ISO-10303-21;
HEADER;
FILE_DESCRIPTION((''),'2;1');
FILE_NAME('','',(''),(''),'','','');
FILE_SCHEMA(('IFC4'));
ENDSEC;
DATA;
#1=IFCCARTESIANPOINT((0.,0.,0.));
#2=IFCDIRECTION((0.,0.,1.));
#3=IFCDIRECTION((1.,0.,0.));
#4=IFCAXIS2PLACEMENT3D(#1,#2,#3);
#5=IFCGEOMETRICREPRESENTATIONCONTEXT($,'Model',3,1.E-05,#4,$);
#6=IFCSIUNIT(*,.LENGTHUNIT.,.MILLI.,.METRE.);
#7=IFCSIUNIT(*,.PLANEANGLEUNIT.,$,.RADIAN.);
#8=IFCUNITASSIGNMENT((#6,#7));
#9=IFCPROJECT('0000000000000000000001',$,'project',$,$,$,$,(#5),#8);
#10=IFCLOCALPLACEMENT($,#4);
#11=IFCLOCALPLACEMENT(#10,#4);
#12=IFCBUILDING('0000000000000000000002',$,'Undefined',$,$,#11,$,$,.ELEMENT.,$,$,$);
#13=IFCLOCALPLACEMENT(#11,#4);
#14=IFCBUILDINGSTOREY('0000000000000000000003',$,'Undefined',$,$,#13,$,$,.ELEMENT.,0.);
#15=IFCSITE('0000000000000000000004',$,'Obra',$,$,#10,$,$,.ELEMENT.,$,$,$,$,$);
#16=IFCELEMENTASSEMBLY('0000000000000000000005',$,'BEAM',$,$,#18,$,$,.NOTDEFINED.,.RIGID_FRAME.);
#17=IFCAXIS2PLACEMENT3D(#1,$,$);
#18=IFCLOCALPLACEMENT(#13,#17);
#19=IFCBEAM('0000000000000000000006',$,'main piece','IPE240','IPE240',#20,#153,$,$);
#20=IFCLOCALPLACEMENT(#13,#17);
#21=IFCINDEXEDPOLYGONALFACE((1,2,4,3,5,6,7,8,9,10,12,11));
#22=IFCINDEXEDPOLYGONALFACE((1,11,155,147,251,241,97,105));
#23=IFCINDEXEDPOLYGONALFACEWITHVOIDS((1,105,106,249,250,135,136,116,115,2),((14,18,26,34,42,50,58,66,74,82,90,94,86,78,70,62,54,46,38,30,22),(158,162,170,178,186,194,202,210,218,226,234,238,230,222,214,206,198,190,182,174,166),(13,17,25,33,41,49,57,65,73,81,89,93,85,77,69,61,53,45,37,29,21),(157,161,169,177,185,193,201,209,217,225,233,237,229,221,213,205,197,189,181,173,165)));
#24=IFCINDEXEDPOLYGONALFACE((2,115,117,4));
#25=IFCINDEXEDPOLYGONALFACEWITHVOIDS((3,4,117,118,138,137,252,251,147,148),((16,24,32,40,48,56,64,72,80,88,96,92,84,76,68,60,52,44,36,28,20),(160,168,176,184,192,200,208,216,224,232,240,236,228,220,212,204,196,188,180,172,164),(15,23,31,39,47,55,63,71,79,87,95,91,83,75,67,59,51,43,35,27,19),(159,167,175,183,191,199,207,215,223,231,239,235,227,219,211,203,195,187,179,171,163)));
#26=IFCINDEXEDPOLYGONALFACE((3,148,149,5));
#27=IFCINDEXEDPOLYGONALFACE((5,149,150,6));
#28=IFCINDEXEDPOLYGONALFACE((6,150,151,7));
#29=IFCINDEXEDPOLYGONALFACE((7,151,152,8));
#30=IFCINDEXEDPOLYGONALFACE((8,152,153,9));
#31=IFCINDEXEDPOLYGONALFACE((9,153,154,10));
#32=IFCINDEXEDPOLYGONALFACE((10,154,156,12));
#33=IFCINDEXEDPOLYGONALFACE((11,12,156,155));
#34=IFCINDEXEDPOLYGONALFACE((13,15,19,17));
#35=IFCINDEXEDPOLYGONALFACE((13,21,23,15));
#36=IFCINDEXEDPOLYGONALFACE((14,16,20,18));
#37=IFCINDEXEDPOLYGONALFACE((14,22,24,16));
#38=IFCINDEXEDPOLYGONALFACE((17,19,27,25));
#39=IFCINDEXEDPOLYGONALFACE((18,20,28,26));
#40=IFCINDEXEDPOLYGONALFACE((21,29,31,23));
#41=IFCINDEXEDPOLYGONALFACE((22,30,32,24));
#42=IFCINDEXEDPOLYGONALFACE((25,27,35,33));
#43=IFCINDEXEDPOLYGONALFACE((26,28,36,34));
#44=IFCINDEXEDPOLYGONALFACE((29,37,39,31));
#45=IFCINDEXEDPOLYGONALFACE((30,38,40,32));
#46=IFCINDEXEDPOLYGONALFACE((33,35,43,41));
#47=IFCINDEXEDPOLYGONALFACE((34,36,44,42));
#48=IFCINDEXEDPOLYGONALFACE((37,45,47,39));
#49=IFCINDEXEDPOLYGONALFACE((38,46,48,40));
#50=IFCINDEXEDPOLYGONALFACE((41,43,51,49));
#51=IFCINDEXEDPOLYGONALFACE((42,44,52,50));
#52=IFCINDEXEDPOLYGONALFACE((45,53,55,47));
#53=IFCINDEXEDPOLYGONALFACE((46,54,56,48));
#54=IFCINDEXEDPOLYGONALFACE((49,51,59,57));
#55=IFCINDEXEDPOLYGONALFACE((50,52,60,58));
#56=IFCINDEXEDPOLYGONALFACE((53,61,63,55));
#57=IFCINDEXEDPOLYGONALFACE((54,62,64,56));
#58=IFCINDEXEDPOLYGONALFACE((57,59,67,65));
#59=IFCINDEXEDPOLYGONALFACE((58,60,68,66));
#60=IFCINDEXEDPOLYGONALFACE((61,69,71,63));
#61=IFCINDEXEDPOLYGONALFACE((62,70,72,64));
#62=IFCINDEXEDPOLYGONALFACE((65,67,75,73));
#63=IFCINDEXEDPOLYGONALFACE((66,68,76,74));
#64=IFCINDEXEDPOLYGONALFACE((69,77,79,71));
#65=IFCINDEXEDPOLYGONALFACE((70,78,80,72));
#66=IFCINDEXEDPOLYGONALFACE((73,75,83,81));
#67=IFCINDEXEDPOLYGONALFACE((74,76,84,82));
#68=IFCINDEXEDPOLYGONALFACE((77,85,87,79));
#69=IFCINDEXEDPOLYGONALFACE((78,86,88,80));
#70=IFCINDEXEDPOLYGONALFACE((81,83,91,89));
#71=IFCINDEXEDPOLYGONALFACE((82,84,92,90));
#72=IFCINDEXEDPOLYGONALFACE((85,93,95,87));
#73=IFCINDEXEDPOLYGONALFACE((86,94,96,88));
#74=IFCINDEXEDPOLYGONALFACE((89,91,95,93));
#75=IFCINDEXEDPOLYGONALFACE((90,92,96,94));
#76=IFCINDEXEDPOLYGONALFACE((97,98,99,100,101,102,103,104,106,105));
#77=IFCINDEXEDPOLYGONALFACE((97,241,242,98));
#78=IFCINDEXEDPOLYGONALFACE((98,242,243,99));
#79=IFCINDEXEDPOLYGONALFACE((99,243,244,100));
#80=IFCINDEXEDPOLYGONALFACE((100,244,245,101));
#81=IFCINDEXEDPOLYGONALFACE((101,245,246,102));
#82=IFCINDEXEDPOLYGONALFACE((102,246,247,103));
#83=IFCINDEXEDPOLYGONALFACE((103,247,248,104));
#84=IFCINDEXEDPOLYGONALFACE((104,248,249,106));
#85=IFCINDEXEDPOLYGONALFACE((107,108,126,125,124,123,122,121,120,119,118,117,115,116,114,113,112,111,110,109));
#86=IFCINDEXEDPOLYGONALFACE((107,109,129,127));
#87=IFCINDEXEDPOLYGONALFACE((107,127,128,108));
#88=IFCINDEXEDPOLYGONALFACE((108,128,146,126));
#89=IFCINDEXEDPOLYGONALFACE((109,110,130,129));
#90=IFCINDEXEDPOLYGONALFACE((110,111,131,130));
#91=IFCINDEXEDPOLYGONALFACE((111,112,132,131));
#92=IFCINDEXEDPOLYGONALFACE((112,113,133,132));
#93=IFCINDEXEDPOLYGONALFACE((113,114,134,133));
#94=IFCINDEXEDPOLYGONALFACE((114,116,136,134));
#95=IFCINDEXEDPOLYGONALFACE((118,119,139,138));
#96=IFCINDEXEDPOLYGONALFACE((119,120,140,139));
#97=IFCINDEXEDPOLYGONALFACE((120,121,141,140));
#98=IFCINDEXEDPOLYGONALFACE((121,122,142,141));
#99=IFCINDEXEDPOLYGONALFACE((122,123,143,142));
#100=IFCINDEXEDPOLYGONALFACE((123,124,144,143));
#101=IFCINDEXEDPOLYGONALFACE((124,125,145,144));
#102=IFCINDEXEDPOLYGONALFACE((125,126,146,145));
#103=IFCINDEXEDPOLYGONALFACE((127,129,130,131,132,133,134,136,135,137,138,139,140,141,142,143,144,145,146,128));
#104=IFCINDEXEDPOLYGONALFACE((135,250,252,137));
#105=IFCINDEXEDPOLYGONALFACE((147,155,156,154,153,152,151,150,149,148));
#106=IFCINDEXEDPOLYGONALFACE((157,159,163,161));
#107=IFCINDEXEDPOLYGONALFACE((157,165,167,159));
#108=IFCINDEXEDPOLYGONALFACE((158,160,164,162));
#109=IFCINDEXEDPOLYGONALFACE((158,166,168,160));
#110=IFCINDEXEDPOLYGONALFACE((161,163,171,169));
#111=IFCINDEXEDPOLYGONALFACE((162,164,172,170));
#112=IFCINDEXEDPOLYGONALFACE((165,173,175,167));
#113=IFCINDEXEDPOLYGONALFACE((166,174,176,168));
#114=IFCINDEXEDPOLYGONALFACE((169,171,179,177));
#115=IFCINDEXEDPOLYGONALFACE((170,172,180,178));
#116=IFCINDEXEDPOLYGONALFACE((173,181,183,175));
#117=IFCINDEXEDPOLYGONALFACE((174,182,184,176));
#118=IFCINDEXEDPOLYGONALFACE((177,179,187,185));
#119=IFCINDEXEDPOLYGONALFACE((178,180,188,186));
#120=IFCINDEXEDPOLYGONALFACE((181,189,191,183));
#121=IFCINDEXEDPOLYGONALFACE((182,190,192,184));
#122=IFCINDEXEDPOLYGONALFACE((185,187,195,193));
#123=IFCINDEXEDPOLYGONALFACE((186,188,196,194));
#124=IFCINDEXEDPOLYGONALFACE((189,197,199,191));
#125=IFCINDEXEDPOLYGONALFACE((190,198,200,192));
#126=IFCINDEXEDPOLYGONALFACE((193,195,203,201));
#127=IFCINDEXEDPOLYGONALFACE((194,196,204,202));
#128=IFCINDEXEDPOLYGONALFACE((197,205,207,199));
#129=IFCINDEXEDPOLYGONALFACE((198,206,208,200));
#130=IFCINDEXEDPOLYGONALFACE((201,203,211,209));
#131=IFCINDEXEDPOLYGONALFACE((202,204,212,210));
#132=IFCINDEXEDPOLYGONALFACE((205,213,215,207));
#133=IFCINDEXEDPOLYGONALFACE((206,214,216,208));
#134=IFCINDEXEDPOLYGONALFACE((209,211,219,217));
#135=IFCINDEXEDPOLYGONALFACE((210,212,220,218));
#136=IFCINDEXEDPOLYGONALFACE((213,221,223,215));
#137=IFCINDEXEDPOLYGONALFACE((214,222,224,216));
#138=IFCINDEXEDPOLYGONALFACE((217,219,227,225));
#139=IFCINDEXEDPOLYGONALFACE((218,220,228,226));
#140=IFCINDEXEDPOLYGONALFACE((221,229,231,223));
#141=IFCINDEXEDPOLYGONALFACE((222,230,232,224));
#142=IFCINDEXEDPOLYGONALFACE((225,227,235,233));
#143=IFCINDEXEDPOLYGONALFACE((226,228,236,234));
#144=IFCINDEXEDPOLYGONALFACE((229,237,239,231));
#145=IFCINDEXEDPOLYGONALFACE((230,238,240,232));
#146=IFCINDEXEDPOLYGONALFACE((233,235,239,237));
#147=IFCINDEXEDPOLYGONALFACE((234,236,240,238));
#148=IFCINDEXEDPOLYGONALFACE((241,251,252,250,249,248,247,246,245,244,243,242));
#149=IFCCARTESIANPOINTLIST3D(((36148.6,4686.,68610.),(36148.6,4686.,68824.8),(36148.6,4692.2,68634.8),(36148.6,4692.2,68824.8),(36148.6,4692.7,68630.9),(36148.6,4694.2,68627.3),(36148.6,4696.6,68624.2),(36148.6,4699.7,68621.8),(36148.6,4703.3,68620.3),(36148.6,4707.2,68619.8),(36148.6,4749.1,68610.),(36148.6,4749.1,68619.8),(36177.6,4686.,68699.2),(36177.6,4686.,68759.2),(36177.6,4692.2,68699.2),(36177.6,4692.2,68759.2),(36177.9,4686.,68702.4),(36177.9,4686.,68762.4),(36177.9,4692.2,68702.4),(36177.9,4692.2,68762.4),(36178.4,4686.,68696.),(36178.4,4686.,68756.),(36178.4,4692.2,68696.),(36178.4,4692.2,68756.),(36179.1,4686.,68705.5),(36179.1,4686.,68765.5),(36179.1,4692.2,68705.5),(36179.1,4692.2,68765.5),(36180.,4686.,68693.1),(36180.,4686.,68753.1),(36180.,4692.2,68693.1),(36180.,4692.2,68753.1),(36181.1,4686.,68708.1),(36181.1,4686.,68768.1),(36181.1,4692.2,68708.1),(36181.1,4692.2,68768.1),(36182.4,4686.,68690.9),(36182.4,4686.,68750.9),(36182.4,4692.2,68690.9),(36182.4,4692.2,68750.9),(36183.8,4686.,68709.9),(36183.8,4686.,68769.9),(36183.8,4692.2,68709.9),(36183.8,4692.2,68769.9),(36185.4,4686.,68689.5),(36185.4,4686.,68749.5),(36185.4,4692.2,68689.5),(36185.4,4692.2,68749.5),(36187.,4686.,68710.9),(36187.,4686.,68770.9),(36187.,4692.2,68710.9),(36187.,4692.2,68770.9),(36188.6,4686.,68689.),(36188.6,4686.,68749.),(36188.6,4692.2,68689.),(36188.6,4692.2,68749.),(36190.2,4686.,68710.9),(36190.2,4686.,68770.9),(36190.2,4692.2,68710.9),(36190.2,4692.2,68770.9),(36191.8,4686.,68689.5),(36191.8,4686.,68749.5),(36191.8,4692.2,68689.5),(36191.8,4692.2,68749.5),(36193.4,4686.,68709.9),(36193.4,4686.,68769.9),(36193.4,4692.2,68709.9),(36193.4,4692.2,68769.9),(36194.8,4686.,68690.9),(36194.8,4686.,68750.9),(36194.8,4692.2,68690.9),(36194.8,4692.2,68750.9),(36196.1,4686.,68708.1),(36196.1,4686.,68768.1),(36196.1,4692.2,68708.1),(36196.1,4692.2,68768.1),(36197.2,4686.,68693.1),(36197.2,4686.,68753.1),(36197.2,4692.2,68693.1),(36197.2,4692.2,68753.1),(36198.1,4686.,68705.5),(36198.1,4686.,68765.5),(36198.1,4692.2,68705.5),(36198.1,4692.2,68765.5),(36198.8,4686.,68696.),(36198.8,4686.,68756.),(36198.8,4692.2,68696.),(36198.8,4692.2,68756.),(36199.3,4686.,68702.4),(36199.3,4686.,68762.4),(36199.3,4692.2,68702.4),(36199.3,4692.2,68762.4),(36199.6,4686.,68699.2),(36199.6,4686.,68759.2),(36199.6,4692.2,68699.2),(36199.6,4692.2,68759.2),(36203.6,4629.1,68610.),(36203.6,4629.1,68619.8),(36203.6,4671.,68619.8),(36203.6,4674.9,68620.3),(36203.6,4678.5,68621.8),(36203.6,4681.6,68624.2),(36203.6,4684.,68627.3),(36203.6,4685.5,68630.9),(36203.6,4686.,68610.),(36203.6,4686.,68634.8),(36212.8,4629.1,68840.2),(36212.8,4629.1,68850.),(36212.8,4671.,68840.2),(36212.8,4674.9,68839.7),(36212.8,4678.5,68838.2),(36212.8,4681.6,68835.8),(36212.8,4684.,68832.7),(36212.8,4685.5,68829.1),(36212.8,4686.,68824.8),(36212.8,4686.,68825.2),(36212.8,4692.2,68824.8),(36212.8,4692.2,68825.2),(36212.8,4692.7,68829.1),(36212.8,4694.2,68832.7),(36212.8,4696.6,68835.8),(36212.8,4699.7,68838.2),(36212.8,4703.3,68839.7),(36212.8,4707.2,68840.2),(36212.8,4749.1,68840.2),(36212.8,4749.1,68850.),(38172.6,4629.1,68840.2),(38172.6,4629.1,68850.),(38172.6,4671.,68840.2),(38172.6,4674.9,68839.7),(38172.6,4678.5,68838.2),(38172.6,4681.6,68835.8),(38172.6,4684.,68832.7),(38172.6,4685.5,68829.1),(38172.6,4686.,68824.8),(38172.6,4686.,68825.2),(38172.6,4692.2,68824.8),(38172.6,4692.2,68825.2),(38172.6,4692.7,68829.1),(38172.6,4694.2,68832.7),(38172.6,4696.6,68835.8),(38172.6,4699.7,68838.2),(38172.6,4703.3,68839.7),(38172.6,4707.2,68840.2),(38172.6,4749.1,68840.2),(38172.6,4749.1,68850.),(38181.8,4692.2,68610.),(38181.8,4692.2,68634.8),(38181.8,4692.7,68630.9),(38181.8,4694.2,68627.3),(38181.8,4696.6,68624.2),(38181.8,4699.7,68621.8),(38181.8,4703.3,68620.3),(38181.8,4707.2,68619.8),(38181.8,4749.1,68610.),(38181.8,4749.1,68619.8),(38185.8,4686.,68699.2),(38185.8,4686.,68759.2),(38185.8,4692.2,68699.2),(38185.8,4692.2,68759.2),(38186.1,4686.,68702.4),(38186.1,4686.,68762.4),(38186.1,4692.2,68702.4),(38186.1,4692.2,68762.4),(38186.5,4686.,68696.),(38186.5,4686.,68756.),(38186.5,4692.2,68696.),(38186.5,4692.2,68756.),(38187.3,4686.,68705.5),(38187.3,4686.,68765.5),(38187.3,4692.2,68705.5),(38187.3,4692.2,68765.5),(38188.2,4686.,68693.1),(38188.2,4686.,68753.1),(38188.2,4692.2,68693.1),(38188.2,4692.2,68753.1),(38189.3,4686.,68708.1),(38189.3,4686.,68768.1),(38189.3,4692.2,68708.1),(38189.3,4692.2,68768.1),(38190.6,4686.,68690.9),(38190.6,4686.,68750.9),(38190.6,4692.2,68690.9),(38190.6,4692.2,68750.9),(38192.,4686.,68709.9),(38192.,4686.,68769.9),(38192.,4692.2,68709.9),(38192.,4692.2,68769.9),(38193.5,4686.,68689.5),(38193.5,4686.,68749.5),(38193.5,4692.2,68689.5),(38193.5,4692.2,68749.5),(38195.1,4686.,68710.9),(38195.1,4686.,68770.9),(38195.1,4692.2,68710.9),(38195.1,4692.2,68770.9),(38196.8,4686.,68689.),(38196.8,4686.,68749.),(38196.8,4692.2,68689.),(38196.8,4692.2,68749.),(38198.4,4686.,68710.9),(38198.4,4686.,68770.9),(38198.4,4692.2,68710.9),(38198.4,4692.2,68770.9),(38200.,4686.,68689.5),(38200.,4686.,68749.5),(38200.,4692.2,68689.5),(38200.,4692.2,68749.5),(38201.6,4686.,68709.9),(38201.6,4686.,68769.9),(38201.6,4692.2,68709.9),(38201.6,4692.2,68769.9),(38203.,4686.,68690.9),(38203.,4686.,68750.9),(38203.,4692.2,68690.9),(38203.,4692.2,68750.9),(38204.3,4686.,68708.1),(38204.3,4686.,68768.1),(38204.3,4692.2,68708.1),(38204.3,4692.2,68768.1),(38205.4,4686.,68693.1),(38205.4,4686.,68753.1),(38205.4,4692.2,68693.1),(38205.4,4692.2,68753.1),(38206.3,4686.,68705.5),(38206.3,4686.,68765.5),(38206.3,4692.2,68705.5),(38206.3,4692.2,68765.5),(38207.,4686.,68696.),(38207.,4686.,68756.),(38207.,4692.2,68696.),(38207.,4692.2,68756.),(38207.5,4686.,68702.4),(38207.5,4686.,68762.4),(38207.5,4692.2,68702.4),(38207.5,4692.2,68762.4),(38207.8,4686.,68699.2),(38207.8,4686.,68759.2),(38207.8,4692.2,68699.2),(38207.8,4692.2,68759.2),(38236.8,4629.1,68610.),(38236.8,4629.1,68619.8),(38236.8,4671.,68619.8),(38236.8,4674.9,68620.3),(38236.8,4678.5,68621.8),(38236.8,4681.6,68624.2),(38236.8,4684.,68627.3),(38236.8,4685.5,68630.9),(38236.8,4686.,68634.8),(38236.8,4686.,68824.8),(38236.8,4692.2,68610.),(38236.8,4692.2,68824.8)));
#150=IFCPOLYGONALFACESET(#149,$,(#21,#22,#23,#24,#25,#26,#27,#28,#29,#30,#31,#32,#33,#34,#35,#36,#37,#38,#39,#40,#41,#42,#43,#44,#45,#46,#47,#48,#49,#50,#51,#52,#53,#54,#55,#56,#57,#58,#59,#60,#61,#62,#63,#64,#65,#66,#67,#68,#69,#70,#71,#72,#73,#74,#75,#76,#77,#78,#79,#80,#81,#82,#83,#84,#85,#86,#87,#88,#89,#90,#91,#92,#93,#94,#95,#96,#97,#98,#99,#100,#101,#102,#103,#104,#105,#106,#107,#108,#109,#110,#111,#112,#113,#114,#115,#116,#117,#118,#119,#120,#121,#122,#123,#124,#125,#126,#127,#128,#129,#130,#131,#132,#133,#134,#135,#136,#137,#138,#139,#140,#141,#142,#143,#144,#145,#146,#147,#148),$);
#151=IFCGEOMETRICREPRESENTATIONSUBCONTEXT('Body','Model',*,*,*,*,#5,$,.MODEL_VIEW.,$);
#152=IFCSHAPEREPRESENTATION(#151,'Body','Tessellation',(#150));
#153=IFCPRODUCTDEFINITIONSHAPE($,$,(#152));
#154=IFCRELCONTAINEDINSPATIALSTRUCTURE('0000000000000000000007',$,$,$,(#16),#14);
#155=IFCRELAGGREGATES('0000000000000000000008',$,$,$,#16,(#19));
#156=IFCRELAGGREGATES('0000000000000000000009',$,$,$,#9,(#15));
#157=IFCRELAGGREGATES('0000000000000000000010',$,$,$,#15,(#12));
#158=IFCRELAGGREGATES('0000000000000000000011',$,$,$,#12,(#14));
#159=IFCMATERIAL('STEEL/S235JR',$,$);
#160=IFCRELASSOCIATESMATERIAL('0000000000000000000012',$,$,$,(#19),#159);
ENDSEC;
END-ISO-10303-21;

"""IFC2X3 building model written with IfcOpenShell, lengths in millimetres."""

from ifc_helpers import new_model, si_unit, frame, origin_with_axes, origin_2d_with_axis, place, context, subcontext, project, spatial, rectangle, circle, i_section, extrude, clip, halfspace, source, transform, mapped, material, element, aggregate, save


model = new_model("IFC2X3")

# Units and contexts
model_context = context("Model", 3, precision=1e-05, world=origin_with_axes())
body_context = subcontext(model_context, "Body", "Model", "MODEL_VIEW")
ifc_project = project(units=[si_unit("LENGTHUNIT", "METRE", prefix="MILLI"), si_unit("PLANEANGLEUNIT", "RADIAN")], contexts=[model_context])

# Site, building, storey
site_placement = place(None, origin_with_axes())
site = spatial("IfcSite", under=ifc_project, at=site_placement, Name="Obra", CompositionType="ELEMENT")
building_placement = place(site_placement, origin_with_axes())
building = spatial("IfcBuilding", under=site, at=building_placement, Name="Undefined", CompositionType="ELEMENT")
storey_placement = place(building_placement, origin_with_axes())
storey = spatial("IfcBuildingStorey", under=building, at=storey_placement, Name="Undefined", CompositionType="ELEMENT", Elevation=0.0)

# Element assembly, beam, openings
ifc_material_1 = material(Name="STEEL/S235JR")
shared_shape_1 = source(origin_with_axes(), body_context, "Body", "SweptSolid", [
    extrude(circle(Radius=11.0, at=origin_2d_with_axis()), frame((0.0, -3.2, 0.0), z_axis=(0.0, 1.0, 0.0), x_axis=(1.0, 0.0, 0.0)), (0.0, 0.0, 1.0), 6.4),
])
assembly_1_placement = place(storey_placement, origin_with_axes())
assembly_1 = element("IfcElementAssembly", 1, at=assembly_1_placement, inside=storey, Name="BEAM", AssemblyPlace="NOTDEFINED", PredefinedType="RIGID_FRAME")
beam_1_placement = place(assembly_1_placement, frame((38169.8, 4689.1, 68730.0), z_axis=(0.0, 0.0, 1.0), x_axis=(-1.0, 0.0, 0.0)))
beam_1 = element("IfcBeam", 2, at=beam_1_placement, material=ifc_material_1, Name="main piece", Description="IPE240", ObjectType="IPE240", context=body_context, shape_type="Clipping", body=[
    clip(clip(extrude(i_section(OverallWidth=120.0, OverallDepth=240.0, WebThickness=6.2, FlangeThickness=9.8, FilletRadius=15.0, at=origin_2d_with_axis()), frame((2021.2, 0.0, 0.0), z_axis=(-1.0, 0.0, 0.0), x_axis=(0.0, -1.0, 0.0)), (0.0, 0.0, 1.0), 2088.2), halfspace(frame((2021.2, 0.0, -220.0), z_axis=(-1.0, 0.0, 0.0), x_axis=(0.0, 1.0, 0.0)), True)), halfspace(frame((-66.9, 0.0, -220.0), z_axis=(1.0, 0.0, 0.0), x_axis=(0.0, -1.0, 0.0)), True)),
])
opening_1_placement = place(assembly_1_placement, frame((38169.8, 4689.1, 68730.0), z_axis=(0.0, 0.0, 1.0), x_axis=(-1.0, 0.0, 0.0)))
element("IfcOpeningElement", 3, at=opening_1_placement, cuts=beam_1, ObjectType="Recess", context=body_context, shape_type="SweptSolid", body=[
    extrude(rectangle(XDim=65.0, YDim=300.0, at=origin_2d_with_axis()), frame((-44.4, -153.1, 109.8), z_axis=(0.0, 0.0, -1.0), x_axis=(1.0, 0.0, 0.0)), (0.0, 0.0, 1.0), 249.6),
])
opening_2_placement = place(assembly_1_placement, frame((38169.8, 4689.1, 68730.0), z_axis=(0.0, 0.0, 1.0), x_axis=(-1.0, 0.0, 0.0)))
element("IfcOpeningElement", 4, at=opening_2_placement, cuts=beam_1, ObjectType="Recess", context=body_context, shape_type="SweptSolid", body=[
    extrude(rectangle(XDim=26.2, YDim=76.2, at=origin_2d_with_axis()), frame((-40.8, -61.0, 107.9), z_axis=(0.0, 1.0, 0.0), x_axis=(0.0, 0.0, -1.0)), (0.0, 0.0, 1.0), 122.0),
])
opening_3_placement = place(assembly_1_placement, frame((38169.8, 4689.1, 68730.0), z_axis=(0.0, 0.0, 1.0), x_axis=(-1.0, 0.0, 0.0)))
element("IfcOpeningElement", 5, at=opening_3_placement, cuts=beam_1, ObjectType="Recess", context=body_context, shape_type="SweptSolid", body=[
    extrude(rectangle(XDim=65.0, YDim=300.0, at=origin_2d_with_axis()), frame((1998.7, 153.1, 109.8), z_axis=(0.0, 0.0, -1.0), x_axis=(-1.0, 0.0, 0.0)), (0.0, 0.0, 1.0), 249.6),
])
opening_4_placement = place(assembly_1_placement, frame((38169.8, 4689.1, 68730.0), z_axis=(0.0, 0.0, 1.0), x_axis=(-1.0, 0.0, 0.0)))
element("IfcOpeningElement", 6, at=opening_4_placement, cuts=beam_1, ObjectType="Recess", context=body_context, shape_type="SweptSolid", body=[
    extrude(rectangle(XDim=26.2, YDim=76.2, at=origin_2d_with_axis()), frame((1995.1, 61.0, 107.9), z_axis=(0.0, -1.0, 0.0), x_axis=(0.0, 0.0, -1.0)), (0.0, 0.0, 1.0), 122.0),
])
opening_5_placement = place(assembly_1_placement, frame((38236.8, 4689.1, 68850.0), z_axis=(-1.0, 0.0, 0.0), x_axis=(0.0, 0.0, -1.0)))
element("IfcOpeningElement", 7, at=opening_5_placement, cuts=beam_1, ObjectType="Opening", context=body_context, shape_type="MappedRepresentation", body=[
    mapped(shared_shape_1, transform((90.0, 0.0, 40.0))),
    mapped(shared_shape_1, transform((150.0, 0.0, 40.0))),
])
opening_6_placement = place(assembly_1_placement, frame((36148.6, 4689.1, 68850.0), z_axis=(1.0, 0.0, 0.0), x_axis=(0.0, 0.0, -1.0)))
element("IfcOpeningElement", 8, at=opening_6_placement, cuts=beam_1, ObjectType="Opening", context=body_context, shape_type="MappedRepresentation", body=[
    mapped(shared_shape_1, transform((90.0, 0.0, 40.0))),
    mapped(shared_shape_1, transform((150.0, 0.0, 40.0))),
])
aggregate(assembly_1, [beam_1])

save(model, "model.ifc")
